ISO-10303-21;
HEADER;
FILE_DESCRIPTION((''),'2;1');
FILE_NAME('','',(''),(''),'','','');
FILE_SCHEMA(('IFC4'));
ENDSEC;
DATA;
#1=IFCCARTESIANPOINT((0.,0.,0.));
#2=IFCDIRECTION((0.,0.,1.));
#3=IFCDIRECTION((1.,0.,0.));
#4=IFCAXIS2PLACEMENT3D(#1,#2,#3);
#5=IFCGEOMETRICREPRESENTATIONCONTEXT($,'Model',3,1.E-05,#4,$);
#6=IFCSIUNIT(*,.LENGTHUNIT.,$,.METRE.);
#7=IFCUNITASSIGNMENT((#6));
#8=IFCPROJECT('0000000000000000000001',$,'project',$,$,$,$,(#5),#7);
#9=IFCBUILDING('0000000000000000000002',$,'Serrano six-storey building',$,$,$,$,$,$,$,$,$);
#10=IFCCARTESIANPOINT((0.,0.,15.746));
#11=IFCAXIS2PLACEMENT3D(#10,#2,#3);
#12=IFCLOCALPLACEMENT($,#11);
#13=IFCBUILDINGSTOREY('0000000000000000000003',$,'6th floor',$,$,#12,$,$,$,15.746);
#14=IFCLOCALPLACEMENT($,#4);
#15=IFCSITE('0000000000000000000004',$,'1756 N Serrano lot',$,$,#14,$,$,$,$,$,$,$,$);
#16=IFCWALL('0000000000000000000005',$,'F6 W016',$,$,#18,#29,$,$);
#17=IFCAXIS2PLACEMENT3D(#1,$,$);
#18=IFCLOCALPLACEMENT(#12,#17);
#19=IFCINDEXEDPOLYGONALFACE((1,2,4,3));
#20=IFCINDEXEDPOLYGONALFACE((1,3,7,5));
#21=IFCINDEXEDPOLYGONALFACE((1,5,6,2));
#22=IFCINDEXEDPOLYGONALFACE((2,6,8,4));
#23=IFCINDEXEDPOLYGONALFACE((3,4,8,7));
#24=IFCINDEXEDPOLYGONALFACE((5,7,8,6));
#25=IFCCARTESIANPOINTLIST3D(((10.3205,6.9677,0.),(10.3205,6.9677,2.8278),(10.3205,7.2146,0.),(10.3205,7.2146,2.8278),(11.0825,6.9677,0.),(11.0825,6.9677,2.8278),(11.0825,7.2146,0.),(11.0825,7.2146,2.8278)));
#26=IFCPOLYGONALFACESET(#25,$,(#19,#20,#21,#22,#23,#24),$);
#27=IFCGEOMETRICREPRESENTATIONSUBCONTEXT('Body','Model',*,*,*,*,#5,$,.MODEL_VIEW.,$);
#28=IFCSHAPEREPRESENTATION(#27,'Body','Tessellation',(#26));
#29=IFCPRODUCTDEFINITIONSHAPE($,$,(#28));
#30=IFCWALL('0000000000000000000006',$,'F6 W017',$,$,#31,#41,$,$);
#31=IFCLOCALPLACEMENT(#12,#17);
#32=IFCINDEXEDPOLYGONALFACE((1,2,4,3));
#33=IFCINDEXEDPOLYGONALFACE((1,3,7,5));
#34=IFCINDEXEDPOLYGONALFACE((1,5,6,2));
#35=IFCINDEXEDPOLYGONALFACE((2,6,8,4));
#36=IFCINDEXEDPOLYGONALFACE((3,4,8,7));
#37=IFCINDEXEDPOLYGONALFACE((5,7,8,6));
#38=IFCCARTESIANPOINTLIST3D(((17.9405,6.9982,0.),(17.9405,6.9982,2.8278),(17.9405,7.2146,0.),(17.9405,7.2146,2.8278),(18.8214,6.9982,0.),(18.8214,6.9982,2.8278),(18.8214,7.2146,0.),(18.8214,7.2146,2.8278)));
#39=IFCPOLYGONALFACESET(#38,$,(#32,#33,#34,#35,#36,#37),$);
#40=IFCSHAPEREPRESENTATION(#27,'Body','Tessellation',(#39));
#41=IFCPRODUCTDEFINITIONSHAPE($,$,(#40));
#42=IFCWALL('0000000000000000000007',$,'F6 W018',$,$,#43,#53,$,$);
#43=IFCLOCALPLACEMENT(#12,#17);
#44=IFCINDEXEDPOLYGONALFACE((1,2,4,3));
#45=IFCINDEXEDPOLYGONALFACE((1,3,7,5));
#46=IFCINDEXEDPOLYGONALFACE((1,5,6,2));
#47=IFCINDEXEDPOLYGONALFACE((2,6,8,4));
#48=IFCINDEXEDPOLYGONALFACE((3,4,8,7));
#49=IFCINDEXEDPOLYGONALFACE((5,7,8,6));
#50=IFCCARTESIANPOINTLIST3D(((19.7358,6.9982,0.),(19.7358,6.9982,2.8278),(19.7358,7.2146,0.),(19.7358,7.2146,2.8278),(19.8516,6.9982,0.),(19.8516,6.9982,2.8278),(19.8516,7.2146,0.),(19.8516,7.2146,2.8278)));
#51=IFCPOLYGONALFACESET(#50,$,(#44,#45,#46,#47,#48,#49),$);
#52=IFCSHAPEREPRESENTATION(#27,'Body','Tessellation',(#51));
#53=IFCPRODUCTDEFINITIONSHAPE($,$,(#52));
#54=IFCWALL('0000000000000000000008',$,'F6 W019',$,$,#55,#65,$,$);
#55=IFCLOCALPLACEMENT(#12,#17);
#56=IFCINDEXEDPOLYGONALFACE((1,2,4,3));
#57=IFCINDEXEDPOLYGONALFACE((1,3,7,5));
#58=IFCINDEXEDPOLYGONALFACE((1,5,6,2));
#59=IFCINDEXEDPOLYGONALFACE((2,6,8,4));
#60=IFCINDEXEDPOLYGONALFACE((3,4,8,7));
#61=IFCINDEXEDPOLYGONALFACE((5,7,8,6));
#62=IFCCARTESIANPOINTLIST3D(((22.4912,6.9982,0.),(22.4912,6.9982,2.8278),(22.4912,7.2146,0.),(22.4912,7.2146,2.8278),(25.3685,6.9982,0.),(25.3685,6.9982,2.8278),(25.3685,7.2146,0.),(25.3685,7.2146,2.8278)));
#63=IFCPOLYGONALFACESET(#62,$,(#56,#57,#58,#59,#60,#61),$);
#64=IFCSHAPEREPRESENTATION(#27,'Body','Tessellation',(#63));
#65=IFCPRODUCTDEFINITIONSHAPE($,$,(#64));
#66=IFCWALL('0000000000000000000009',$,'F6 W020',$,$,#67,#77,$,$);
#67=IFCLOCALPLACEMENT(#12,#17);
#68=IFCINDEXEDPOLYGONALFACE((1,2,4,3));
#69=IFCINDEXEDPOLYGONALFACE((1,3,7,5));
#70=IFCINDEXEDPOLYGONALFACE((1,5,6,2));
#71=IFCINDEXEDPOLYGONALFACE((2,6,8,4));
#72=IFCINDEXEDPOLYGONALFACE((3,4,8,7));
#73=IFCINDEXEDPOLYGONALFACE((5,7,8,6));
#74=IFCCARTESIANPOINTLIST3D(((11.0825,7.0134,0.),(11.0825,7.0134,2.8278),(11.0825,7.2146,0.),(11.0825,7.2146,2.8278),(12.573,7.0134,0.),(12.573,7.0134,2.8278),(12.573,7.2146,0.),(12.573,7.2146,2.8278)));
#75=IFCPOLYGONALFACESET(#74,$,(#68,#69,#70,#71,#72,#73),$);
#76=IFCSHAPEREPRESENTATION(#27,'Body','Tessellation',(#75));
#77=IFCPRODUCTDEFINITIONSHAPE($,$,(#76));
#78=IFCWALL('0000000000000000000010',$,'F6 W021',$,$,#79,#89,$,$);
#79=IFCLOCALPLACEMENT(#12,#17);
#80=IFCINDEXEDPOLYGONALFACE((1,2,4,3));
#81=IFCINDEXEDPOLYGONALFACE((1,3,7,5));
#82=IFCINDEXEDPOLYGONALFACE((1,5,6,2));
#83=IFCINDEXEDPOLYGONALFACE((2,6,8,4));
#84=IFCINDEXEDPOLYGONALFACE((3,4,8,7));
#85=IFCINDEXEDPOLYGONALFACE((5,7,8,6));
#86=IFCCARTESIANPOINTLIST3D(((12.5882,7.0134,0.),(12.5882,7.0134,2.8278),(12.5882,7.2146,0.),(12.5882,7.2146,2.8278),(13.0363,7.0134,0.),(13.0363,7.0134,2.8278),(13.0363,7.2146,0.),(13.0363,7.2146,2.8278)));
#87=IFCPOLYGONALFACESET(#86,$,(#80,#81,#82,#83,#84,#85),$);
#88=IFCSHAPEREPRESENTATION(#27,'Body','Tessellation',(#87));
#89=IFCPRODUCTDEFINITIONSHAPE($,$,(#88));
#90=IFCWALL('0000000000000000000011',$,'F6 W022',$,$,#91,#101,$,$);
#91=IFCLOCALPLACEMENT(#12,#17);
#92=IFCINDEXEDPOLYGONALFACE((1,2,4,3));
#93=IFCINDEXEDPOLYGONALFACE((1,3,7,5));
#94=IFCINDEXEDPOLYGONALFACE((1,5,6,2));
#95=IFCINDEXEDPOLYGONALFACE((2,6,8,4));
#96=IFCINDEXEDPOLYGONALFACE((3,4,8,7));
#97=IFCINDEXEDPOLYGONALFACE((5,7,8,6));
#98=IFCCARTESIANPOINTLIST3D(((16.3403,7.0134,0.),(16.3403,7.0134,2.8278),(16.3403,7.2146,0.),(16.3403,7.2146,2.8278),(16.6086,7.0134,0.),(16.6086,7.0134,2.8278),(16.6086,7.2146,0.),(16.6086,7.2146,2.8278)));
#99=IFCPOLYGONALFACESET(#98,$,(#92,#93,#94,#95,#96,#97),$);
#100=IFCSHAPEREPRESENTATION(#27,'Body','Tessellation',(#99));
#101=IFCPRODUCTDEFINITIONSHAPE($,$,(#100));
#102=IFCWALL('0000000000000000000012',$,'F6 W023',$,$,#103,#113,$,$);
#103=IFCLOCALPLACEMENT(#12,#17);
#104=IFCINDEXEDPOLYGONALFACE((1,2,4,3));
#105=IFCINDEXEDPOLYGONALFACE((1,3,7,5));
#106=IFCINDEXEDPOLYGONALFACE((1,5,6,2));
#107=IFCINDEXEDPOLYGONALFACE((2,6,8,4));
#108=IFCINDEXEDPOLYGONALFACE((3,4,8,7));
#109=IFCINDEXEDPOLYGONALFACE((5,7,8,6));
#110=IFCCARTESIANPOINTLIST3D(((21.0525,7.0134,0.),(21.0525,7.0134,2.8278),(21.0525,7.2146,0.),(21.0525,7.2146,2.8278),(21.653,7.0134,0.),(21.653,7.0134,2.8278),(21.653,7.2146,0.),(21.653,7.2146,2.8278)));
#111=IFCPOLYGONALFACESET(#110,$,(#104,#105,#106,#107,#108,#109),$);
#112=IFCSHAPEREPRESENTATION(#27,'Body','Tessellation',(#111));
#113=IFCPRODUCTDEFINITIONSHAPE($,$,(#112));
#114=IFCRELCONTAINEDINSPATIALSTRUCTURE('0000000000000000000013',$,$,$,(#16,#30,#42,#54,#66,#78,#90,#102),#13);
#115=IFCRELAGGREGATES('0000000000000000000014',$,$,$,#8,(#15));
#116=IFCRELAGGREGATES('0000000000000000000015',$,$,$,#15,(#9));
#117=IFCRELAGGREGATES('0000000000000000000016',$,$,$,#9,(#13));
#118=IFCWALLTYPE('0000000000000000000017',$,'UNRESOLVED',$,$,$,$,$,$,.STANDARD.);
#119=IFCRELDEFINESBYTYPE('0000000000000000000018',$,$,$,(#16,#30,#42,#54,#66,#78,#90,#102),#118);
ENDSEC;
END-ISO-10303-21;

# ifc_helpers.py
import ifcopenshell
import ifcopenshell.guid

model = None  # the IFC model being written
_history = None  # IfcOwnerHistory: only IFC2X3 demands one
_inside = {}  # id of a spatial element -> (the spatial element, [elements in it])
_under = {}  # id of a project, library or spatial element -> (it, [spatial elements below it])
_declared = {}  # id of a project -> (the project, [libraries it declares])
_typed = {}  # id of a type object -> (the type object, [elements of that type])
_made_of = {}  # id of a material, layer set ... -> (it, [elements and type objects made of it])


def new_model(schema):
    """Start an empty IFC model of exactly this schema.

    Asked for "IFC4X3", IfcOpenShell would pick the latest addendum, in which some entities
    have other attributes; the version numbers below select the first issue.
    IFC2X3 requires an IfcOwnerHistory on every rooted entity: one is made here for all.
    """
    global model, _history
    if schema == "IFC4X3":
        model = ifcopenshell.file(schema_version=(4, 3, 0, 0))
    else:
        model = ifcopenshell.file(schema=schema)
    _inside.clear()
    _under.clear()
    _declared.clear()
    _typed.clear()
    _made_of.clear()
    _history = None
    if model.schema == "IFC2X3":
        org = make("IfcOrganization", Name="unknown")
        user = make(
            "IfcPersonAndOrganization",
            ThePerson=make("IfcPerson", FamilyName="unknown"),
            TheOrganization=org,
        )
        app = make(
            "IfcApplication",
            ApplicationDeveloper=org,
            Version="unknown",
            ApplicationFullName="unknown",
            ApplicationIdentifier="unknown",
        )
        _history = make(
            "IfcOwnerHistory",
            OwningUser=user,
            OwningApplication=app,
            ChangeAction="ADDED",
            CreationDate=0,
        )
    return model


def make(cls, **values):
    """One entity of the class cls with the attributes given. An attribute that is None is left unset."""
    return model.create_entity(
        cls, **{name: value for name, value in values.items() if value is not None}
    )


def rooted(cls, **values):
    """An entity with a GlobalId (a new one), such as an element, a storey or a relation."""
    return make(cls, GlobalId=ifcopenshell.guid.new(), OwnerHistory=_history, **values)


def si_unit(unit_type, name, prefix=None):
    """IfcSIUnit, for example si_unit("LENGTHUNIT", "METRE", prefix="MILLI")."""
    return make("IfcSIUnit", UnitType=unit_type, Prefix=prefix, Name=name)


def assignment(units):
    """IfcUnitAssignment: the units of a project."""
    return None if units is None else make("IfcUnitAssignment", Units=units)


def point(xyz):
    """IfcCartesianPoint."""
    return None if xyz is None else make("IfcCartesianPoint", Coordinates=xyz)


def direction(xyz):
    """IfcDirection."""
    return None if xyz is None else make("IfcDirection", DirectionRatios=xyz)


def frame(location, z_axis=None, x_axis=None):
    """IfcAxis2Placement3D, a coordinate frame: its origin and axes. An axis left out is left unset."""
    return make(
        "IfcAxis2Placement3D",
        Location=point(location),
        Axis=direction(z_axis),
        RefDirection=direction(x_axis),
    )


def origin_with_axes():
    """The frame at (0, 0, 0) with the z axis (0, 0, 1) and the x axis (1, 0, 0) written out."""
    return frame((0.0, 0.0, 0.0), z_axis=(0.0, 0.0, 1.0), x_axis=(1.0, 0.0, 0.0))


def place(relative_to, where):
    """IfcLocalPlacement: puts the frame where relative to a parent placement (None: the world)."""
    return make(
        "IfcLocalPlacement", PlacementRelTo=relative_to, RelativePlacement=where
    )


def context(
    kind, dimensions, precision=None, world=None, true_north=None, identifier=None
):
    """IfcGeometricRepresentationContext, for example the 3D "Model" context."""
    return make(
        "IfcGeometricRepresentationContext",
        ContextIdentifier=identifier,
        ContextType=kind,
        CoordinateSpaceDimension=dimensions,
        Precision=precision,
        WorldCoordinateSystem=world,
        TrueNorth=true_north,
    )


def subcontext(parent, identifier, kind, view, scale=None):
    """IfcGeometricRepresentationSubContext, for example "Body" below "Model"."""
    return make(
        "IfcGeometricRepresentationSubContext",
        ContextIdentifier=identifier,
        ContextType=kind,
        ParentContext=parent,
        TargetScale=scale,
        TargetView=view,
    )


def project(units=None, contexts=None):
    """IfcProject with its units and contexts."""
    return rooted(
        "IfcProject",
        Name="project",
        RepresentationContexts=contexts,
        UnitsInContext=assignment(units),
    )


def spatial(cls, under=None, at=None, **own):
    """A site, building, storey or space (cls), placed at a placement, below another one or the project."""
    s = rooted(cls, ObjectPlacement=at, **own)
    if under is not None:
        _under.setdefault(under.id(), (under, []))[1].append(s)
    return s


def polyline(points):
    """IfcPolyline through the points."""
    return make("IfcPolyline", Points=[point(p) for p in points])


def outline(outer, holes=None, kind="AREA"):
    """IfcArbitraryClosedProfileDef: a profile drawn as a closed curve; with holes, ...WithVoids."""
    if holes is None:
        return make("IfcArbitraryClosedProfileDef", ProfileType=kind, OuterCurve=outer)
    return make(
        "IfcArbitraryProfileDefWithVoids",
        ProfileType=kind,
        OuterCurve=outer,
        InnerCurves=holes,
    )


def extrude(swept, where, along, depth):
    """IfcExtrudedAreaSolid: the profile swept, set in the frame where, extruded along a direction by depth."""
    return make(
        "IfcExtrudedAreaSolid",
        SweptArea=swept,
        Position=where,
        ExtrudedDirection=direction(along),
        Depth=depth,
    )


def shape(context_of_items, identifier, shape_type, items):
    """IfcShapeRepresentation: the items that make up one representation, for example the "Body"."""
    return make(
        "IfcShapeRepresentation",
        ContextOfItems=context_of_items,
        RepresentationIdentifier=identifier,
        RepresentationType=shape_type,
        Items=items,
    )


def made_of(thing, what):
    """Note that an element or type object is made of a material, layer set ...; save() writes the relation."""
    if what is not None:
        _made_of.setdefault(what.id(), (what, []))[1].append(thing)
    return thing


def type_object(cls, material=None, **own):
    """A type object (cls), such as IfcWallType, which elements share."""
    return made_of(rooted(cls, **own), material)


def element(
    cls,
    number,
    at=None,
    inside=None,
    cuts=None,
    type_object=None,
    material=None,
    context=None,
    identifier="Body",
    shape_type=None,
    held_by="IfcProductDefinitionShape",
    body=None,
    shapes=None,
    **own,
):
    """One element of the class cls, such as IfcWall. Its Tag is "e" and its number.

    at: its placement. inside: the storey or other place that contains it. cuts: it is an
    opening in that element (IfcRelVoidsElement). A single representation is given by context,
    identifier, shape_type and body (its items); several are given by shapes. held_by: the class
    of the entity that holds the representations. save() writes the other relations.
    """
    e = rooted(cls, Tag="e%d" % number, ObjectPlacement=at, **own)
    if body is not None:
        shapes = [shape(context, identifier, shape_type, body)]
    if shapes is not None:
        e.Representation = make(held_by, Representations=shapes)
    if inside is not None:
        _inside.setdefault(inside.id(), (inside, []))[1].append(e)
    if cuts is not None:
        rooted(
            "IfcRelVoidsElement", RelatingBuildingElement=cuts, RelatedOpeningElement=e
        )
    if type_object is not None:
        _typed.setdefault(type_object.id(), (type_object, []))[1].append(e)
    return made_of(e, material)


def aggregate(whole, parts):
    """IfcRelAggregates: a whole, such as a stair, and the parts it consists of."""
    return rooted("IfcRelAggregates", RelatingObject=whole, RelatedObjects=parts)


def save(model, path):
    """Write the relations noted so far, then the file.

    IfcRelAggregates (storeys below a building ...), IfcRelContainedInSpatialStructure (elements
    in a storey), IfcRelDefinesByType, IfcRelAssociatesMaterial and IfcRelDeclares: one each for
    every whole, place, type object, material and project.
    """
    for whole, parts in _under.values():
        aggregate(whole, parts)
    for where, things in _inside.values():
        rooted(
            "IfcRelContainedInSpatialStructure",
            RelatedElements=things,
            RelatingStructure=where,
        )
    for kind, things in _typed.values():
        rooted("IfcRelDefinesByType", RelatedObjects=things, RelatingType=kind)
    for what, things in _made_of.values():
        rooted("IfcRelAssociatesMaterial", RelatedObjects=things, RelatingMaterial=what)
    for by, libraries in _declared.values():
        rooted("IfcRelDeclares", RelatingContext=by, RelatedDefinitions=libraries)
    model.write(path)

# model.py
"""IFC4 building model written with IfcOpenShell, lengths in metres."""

from ifc_helpers import new_model, si_unit, frame, origin_with_axes, place, context, subcontext, project, spatial, polyline, outline, extrude, type_object, element, save


model = new_model("IFC4")

# Units and contexts
model_context = context("Model", 3, precision=1e-05, world=origin_with_axes())
body_context = subcontext(model_context, "Body", "Model", "MODEL_VIEW")
ifc_project = project(units=[si_unit("LENGTHUNIT", "METRE")], contexts=[model_context])

# Site, building, storey
site_placement = place(None, origin_with_axes())
site = spatial("IfcSite", under=ifc_project, at=site_placement, Name="1756 N Serrano lot")
building = spatial("IfcBuilding", under=site, Name="Serrano six-storey building")
storey_placement = place(None, frame((0.0, 0.0, 15.746), z_axis=(0.0, 0.0, 1.0), x_axis=(1.0, 0.0, 0.0)))
storey = spatial("IfcBuildingStorey", under=building, at=storey_placement, Name="6th floor", Elevation=15.746)

# Walls
wall_type = type_object("IfcWallType", Name="UNRESOLVED", PredefinedType="STANDARD")
wall_1_placement = place(storey_placement, frame((0.0, 0.0, -15.746), z_axis=(0.0, 0.0, 1.0), x_axis=(1.0, 0.0, 0.0)))
element("IfcWall", 1, at=wall_1_placement, inside=storey, type_object=wall_type, Name="F6 W016", context=body_context, shape_type="SweptSolid", body=[
    extrude(outline(polyline([(11.0825, 7.2146), (11.0825, 6.9677), (10.3205, 6.9677), (10.3205, 7.2146), (11.0825, 7.2146)])), frame((0.0, 0.0, 15.746)), (0.0, 0.0, 1.0), 2.8278),
])
wall_2_placement = place(storey_placement, frame((0.0, 0.0, -15.746), z_axis=(0.0, 0.0, 1.0), x_axis=(1.0, 0.0, 0.0)))
element("IfcWall", 2, at=wall_2_placement, inside=storey, type_object=wall_type, Name="F6 W017", context=body_context, shape_type="SweptSolid", body=[
    extrude(outline(polyline([(18.8214, 7.2146), (18.8214, 6.9982), (17.9405, 6.9982), (17.9405, 7.2146), (18.8214, 7.2146)])), frame((0.0, 0.0, 15.746)), (0.0, 0.0, 1.0), 2.8278),
])
wall_3_placement = place(storey_placement, frame((0.0, 0.0, -15.746), z_axis=(0.0, 0.0, 1.0), x_axis=(1.0, 0.0, 0.0)))
element("IfcWall", 3, at=wall_3_placement, inside=storey, type_object=wall_type, Name="F6 W018", context=body_context, shape_type="SweptSolid", body=[
    extrude(outline(polyline([(19.8516, 7.2146), (19.8516, 6.9982), (19.7358, 6.9982), (19.7358, 7.2146), (19.8516, 7.2146)])), frame((0.0, 0.0, 15.746)), (0.0, 0.0, 1.0), 2.8278),
])
wall_4_placement = place(storey_placement, frame((0.0, 0.0, -15.746), z_axis=(0.0, 0.0, 1.0), x_axis=(1.0, 0.0, 0.0)))
element("IfcWall", 4, at=wall_4_placement, inside=storey, type_object=wall_type, Name="F6 W019", context=body_context, shape_type="SweptSolid", body=[
    extrude(outline(polyline([(25.3685, 7.2146), (25.3685, 6.9982), (22.4912, 6.9982), (22.4912, 7.2146), (25.3685, 7.2146)])), frame((0.0, 0.0, 15.746)), (0.0, 0.0, 1.0), 2.8278),
])
wall_5_placement = place(storey_placement, frame((0.0, 0.0, -15.746), z_axis=(0.0, 0.0, 1.0), x_axis=(1.0, 0.0, 0.0)))
element("IfcWall", 5, at=wall_5_placement, inside=storey, type_object=wall_type, Name="F6 W020", context=body_context, shape_type="SweptSolid", body=[
    extrude(outline(polyline([(12.573, 7.2146), (12.573, 7.0134), (11.0825, 7.0134), (11.0825, 7.2146), (12.573, 7.2146)])), frame((0.0, 0.0, 15.746)), (0.0, 0.0, 1.0), 2.8278),
])
wall_6_placement = place(storey_placement, frame((0.0, 0.0, -15.746), z_axis=(0.0, 0.0, 1.0), x_axis=(1.0, 0.0, 0.0)))
element("IfcWall", 6, at=wall_6_placement, inside=storey, type_object=wall_type, Name="F6 W021", context=body_context, shape_type="SweptSolid", body=[
    extrude(outline(polyline([(13.0363, 7.2146), (13.0363, 7.0134), (12.5882, 7.0134), (12.5882, 7.2146), (13.0363, 7.2146)])), frame((0.0, 0.0, 15.746)), (0.0, 0.0, 1.0), 2.8278),
])
wall_7_placement = place(storey_placement, frame((0.0, 0.0, -15.746), z_axis=(0.0, 0.0, 1.0), x_axis=(1.0, 0.0, 0.0)))
element("IfcWall", 7, at=wall_7_placement, inside=storey, type_object=wall_type, Name="F6 W022", context=body_context, shape_type="SweptSolid", body=[
    extrude(outline(polyline([(16.6086, 7.2146), (16.6086, 7.0134), (16.3403, 7.0134), (16.3403, 7.2146), (16.6086, 7.2146)])), frame((0.0, 0.0, 15.746)), (0.0, 0.0, 1.0), 2.8278),
])
wall_8_placement = place(storey_placement, frame((0.0, 0.0, -15.746), z_axis=(0.0, 0.0, 1.0), x_axis=(1.0, 0.0, 0.0)))
element("IfcWall", 8, at=wall_8_placement, inside=storey, type_object=wall_type, Name="F6 W023", context=body_context, shape_type="SweptSolid", body=[
    extrude(outline(polyline([(21.653, 7.2146), (21.653, 7.0134), (21.0525, 7.0134), (21.0525, 7.2146), (21.653, 7.2146)])), frame((0.0, 0.0, 15.746)), (0.0, 0.0, 1.0), 2.8278),
])

save(model, "model.ifc")
